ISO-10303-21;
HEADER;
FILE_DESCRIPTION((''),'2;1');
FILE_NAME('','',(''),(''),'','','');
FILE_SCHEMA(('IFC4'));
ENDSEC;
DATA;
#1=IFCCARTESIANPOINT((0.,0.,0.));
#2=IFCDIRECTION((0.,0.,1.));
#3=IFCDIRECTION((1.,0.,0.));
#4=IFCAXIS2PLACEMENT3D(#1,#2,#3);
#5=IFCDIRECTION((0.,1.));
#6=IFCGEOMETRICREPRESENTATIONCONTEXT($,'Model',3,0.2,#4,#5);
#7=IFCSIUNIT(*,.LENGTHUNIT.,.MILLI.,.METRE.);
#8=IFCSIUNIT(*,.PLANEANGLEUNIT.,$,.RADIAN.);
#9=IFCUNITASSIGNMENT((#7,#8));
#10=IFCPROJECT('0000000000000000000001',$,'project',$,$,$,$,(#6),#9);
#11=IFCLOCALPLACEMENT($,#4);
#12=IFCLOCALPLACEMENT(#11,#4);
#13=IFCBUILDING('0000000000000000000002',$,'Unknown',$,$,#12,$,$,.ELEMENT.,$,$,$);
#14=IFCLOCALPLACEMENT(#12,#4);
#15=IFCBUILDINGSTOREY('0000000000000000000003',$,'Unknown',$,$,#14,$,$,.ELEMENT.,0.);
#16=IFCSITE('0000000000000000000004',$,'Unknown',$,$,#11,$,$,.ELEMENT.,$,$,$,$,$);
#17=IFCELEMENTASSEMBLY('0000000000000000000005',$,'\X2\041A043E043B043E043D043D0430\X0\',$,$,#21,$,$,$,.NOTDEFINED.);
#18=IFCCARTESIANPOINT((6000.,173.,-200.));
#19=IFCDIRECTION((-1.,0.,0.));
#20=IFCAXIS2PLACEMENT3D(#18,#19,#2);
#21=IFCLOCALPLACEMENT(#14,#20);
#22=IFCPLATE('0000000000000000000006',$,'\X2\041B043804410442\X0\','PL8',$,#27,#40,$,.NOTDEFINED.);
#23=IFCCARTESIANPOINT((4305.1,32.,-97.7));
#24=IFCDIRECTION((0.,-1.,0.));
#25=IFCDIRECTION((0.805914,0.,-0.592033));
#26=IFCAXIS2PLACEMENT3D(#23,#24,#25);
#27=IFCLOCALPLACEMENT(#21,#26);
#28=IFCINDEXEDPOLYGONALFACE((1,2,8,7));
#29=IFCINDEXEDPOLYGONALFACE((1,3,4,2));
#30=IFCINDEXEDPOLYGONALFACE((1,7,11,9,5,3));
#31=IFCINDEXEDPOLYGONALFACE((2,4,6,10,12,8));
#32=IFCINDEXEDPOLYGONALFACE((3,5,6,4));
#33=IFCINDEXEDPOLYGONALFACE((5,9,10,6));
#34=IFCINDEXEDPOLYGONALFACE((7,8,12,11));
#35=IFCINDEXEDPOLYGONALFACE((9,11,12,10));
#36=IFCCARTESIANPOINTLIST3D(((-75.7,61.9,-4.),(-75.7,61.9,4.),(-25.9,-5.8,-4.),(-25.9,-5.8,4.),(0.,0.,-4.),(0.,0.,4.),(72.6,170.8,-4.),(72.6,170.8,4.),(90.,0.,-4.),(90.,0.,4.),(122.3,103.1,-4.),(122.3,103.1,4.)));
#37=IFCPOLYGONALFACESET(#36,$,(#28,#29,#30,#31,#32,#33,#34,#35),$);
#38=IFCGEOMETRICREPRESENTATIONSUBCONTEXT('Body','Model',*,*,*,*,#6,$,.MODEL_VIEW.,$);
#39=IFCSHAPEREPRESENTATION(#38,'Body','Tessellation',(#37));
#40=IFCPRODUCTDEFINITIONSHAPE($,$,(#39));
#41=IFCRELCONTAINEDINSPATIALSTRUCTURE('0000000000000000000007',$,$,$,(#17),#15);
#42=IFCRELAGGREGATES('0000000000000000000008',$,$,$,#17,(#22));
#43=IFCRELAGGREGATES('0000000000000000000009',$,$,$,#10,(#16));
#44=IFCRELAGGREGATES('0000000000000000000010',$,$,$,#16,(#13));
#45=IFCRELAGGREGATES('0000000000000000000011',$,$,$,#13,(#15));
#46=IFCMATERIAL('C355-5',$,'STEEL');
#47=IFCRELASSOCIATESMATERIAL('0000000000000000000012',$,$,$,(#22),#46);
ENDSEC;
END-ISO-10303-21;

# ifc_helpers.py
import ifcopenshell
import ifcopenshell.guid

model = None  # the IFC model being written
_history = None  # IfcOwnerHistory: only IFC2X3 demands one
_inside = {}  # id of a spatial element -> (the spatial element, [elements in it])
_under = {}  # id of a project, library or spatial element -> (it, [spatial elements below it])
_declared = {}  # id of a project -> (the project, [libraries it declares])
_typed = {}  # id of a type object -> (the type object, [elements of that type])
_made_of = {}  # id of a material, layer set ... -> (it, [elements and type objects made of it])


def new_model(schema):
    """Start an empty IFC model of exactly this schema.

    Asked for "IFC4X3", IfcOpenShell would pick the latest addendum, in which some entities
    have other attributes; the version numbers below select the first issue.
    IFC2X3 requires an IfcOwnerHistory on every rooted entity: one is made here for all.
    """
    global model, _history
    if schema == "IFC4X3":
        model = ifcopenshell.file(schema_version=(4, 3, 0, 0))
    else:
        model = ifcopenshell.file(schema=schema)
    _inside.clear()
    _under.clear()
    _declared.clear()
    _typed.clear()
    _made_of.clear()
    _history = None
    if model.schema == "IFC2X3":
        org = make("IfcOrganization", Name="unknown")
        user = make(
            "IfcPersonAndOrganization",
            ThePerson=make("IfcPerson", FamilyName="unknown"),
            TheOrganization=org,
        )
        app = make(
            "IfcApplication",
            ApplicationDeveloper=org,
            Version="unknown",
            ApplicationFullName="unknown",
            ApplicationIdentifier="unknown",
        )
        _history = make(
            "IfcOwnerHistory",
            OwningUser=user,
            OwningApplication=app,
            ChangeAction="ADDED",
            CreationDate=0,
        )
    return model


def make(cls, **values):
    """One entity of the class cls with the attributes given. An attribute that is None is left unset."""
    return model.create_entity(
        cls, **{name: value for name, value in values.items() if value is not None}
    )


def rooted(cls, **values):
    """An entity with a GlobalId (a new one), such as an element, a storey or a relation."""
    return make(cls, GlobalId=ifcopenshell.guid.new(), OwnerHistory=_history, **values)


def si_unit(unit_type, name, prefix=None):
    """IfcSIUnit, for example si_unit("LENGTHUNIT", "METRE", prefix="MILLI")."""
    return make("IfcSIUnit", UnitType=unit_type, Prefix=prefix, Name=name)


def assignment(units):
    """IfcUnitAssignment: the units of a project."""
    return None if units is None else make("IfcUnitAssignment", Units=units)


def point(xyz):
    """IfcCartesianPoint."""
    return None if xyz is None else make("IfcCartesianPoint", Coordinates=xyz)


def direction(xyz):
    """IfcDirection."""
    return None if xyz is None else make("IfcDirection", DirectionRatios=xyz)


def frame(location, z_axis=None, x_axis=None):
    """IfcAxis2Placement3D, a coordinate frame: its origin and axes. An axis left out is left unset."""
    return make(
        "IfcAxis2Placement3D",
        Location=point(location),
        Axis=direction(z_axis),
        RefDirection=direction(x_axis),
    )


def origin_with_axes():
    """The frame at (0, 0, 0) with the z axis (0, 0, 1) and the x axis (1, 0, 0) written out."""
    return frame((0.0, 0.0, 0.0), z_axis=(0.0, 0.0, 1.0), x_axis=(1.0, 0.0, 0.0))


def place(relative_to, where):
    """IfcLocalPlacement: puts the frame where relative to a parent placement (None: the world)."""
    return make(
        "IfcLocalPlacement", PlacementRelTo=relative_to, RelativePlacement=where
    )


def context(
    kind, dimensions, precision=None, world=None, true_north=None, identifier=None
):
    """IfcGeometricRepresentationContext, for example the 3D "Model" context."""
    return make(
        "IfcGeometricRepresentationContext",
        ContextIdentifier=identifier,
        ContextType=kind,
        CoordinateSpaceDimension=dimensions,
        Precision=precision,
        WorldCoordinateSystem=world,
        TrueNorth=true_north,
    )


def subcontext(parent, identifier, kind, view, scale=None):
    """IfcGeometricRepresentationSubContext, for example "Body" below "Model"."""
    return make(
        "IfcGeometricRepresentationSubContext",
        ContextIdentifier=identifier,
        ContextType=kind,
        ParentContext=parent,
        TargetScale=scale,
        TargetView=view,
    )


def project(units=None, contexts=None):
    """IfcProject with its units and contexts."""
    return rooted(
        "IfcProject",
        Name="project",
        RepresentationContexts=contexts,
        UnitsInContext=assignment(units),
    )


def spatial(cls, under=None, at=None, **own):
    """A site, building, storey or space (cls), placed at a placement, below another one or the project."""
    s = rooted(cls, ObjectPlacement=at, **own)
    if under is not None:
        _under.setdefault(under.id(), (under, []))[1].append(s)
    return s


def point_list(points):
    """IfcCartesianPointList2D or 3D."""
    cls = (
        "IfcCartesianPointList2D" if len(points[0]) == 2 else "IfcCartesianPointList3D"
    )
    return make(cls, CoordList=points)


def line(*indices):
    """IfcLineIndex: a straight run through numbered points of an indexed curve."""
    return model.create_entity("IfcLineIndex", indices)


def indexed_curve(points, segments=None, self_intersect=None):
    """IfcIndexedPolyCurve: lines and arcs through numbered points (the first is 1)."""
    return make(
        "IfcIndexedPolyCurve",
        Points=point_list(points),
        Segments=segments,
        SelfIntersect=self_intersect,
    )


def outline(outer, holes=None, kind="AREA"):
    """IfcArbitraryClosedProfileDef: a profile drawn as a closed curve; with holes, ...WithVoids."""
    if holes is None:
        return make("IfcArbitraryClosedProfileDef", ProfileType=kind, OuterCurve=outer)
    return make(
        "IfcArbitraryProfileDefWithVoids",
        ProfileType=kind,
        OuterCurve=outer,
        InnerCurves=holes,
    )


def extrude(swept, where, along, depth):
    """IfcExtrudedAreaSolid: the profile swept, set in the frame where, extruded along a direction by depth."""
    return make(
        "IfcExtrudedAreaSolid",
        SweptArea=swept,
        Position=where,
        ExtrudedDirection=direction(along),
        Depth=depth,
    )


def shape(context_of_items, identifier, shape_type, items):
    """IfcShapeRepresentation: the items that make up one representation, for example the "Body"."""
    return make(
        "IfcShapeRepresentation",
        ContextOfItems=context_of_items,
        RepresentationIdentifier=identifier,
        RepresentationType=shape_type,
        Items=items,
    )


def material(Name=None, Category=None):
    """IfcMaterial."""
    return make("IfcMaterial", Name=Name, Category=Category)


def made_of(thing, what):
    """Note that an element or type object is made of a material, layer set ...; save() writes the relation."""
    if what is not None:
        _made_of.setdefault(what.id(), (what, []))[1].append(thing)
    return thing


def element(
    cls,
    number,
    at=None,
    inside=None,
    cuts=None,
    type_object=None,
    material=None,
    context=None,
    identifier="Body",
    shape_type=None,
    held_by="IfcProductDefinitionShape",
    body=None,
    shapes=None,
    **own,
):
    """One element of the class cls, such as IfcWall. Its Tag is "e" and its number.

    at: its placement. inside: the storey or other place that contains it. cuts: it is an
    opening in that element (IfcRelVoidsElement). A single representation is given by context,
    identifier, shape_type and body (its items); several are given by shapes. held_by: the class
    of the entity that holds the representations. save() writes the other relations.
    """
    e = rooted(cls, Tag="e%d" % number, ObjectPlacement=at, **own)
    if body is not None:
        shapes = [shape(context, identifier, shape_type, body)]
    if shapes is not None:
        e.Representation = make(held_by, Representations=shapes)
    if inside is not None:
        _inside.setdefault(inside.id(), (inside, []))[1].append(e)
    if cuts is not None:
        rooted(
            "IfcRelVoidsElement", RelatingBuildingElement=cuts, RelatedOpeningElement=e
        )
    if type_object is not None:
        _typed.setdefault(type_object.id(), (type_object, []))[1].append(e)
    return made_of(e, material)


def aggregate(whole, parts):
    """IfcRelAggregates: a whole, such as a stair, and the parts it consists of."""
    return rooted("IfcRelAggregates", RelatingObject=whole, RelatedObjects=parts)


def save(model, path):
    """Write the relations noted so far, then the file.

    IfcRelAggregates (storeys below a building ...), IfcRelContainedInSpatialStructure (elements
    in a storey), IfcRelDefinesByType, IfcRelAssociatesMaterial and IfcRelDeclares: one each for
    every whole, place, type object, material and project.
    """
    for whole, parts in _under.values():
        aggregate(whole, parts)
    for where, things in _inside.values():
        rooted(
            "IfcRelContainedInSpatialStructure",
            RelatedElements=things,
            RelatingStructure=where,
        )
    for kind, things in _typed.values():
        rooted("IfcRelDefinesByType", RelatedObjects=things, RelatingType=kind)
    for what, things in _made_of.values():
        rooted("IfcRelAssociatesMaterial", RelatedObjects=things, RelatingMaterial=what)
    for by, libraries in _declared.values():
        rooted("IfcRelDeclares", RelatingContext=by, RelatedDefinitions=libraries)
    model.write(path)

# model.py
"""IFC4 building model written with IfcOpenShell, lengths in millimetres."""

from ifc_helpers import new_model, si_unit, direction, frame, origin_with_axes, place, context, subcontext, project, spatial, line, indexed_curve, outline, extrude, material, element, aggregate, save


model = new_model("IFC4")

# Units and contexts
model_context = context("Model", 3, precision=0.2, world=origin_with_axes(), true_north=direction((0.0, 1.0)))
body_context = subcontext(model_context, "Body", "Model", "MODEL_VIEW")
ifc_project = project(units=[si_unit("LENGTHUNIT", "METRE", prefix="MILLI"), si_unit("PLANEANGLEUNIT", "RADIAN")], contexts=[model_context])

# Site, building, storey
site_placement = place(None, origin_with_axes())
site = spatial("IfcSite", under=ifc_project, at=site_placement, Name="Unknown", CompositionType="ELEMENT")
building_placement = place(site_placement, origin_with_axes())
building = spatial("IfcBuilding", under=site, at=building_placement, Name="Unknown", CompositionType="ELEMENT")
storey_placement = place(building_placement, origin_with_axes())
storey = spatial("IfcBuildingStorey", under=building, at=storey_placement, Name="Unknown", CompositionType="ELEMENT", Elevation=0.0)

# Element assembly
assembly_1_placement = place(storey_placement, frame((6000.0, 173.0, -200.0), z_axis=(-1.0, 0.0, 0.0), x_axis=(0.0, 0.0, 1.0)))
assembly_1 = element("IfcElementAssembly", 1, at=assembly_1_placement, inside=storey, Name="Колонна", PredefinedType="NOTDEFINED")
ifc_material_1 = material(Name="C355-5", Category="STEEL")

# Plate
plate_1_placement = place(assembly_1_placement, frame((4305.1, 32.0, -97.7), z_axis=(0.0, -1.0, 0.0), x_axis=(0.805914, 0.0, -0.592033)))
plate_1 = element("IfcPlate", 2, at=plate_1_placement, material=ifc_material_1, Name="Лист", Description="PL8", PredefinedType="NOTDEFINED", context=body_context, shape_type="SolidModel", body=[
    extrude(outline(indexed_curve([(0.0, 0.0), (90.0, 0.0), (122.3, 103.1), (72.6, 170.8), (-75.7, 61.9), (-25.9, -5.8)], segments=[line(1, 2, 3, 4, 5, 6, 1)])), frame((0.0, 0.0, 4.0), z_axis=(0.0, 0.0, 1.0), x_axis=(1.0, 0.0, 0.0)), (0.0, 0.0, -1.0), 8.0),
])
aggregate(assembly_1, [plate_1])

save(model, "model.ifc")
